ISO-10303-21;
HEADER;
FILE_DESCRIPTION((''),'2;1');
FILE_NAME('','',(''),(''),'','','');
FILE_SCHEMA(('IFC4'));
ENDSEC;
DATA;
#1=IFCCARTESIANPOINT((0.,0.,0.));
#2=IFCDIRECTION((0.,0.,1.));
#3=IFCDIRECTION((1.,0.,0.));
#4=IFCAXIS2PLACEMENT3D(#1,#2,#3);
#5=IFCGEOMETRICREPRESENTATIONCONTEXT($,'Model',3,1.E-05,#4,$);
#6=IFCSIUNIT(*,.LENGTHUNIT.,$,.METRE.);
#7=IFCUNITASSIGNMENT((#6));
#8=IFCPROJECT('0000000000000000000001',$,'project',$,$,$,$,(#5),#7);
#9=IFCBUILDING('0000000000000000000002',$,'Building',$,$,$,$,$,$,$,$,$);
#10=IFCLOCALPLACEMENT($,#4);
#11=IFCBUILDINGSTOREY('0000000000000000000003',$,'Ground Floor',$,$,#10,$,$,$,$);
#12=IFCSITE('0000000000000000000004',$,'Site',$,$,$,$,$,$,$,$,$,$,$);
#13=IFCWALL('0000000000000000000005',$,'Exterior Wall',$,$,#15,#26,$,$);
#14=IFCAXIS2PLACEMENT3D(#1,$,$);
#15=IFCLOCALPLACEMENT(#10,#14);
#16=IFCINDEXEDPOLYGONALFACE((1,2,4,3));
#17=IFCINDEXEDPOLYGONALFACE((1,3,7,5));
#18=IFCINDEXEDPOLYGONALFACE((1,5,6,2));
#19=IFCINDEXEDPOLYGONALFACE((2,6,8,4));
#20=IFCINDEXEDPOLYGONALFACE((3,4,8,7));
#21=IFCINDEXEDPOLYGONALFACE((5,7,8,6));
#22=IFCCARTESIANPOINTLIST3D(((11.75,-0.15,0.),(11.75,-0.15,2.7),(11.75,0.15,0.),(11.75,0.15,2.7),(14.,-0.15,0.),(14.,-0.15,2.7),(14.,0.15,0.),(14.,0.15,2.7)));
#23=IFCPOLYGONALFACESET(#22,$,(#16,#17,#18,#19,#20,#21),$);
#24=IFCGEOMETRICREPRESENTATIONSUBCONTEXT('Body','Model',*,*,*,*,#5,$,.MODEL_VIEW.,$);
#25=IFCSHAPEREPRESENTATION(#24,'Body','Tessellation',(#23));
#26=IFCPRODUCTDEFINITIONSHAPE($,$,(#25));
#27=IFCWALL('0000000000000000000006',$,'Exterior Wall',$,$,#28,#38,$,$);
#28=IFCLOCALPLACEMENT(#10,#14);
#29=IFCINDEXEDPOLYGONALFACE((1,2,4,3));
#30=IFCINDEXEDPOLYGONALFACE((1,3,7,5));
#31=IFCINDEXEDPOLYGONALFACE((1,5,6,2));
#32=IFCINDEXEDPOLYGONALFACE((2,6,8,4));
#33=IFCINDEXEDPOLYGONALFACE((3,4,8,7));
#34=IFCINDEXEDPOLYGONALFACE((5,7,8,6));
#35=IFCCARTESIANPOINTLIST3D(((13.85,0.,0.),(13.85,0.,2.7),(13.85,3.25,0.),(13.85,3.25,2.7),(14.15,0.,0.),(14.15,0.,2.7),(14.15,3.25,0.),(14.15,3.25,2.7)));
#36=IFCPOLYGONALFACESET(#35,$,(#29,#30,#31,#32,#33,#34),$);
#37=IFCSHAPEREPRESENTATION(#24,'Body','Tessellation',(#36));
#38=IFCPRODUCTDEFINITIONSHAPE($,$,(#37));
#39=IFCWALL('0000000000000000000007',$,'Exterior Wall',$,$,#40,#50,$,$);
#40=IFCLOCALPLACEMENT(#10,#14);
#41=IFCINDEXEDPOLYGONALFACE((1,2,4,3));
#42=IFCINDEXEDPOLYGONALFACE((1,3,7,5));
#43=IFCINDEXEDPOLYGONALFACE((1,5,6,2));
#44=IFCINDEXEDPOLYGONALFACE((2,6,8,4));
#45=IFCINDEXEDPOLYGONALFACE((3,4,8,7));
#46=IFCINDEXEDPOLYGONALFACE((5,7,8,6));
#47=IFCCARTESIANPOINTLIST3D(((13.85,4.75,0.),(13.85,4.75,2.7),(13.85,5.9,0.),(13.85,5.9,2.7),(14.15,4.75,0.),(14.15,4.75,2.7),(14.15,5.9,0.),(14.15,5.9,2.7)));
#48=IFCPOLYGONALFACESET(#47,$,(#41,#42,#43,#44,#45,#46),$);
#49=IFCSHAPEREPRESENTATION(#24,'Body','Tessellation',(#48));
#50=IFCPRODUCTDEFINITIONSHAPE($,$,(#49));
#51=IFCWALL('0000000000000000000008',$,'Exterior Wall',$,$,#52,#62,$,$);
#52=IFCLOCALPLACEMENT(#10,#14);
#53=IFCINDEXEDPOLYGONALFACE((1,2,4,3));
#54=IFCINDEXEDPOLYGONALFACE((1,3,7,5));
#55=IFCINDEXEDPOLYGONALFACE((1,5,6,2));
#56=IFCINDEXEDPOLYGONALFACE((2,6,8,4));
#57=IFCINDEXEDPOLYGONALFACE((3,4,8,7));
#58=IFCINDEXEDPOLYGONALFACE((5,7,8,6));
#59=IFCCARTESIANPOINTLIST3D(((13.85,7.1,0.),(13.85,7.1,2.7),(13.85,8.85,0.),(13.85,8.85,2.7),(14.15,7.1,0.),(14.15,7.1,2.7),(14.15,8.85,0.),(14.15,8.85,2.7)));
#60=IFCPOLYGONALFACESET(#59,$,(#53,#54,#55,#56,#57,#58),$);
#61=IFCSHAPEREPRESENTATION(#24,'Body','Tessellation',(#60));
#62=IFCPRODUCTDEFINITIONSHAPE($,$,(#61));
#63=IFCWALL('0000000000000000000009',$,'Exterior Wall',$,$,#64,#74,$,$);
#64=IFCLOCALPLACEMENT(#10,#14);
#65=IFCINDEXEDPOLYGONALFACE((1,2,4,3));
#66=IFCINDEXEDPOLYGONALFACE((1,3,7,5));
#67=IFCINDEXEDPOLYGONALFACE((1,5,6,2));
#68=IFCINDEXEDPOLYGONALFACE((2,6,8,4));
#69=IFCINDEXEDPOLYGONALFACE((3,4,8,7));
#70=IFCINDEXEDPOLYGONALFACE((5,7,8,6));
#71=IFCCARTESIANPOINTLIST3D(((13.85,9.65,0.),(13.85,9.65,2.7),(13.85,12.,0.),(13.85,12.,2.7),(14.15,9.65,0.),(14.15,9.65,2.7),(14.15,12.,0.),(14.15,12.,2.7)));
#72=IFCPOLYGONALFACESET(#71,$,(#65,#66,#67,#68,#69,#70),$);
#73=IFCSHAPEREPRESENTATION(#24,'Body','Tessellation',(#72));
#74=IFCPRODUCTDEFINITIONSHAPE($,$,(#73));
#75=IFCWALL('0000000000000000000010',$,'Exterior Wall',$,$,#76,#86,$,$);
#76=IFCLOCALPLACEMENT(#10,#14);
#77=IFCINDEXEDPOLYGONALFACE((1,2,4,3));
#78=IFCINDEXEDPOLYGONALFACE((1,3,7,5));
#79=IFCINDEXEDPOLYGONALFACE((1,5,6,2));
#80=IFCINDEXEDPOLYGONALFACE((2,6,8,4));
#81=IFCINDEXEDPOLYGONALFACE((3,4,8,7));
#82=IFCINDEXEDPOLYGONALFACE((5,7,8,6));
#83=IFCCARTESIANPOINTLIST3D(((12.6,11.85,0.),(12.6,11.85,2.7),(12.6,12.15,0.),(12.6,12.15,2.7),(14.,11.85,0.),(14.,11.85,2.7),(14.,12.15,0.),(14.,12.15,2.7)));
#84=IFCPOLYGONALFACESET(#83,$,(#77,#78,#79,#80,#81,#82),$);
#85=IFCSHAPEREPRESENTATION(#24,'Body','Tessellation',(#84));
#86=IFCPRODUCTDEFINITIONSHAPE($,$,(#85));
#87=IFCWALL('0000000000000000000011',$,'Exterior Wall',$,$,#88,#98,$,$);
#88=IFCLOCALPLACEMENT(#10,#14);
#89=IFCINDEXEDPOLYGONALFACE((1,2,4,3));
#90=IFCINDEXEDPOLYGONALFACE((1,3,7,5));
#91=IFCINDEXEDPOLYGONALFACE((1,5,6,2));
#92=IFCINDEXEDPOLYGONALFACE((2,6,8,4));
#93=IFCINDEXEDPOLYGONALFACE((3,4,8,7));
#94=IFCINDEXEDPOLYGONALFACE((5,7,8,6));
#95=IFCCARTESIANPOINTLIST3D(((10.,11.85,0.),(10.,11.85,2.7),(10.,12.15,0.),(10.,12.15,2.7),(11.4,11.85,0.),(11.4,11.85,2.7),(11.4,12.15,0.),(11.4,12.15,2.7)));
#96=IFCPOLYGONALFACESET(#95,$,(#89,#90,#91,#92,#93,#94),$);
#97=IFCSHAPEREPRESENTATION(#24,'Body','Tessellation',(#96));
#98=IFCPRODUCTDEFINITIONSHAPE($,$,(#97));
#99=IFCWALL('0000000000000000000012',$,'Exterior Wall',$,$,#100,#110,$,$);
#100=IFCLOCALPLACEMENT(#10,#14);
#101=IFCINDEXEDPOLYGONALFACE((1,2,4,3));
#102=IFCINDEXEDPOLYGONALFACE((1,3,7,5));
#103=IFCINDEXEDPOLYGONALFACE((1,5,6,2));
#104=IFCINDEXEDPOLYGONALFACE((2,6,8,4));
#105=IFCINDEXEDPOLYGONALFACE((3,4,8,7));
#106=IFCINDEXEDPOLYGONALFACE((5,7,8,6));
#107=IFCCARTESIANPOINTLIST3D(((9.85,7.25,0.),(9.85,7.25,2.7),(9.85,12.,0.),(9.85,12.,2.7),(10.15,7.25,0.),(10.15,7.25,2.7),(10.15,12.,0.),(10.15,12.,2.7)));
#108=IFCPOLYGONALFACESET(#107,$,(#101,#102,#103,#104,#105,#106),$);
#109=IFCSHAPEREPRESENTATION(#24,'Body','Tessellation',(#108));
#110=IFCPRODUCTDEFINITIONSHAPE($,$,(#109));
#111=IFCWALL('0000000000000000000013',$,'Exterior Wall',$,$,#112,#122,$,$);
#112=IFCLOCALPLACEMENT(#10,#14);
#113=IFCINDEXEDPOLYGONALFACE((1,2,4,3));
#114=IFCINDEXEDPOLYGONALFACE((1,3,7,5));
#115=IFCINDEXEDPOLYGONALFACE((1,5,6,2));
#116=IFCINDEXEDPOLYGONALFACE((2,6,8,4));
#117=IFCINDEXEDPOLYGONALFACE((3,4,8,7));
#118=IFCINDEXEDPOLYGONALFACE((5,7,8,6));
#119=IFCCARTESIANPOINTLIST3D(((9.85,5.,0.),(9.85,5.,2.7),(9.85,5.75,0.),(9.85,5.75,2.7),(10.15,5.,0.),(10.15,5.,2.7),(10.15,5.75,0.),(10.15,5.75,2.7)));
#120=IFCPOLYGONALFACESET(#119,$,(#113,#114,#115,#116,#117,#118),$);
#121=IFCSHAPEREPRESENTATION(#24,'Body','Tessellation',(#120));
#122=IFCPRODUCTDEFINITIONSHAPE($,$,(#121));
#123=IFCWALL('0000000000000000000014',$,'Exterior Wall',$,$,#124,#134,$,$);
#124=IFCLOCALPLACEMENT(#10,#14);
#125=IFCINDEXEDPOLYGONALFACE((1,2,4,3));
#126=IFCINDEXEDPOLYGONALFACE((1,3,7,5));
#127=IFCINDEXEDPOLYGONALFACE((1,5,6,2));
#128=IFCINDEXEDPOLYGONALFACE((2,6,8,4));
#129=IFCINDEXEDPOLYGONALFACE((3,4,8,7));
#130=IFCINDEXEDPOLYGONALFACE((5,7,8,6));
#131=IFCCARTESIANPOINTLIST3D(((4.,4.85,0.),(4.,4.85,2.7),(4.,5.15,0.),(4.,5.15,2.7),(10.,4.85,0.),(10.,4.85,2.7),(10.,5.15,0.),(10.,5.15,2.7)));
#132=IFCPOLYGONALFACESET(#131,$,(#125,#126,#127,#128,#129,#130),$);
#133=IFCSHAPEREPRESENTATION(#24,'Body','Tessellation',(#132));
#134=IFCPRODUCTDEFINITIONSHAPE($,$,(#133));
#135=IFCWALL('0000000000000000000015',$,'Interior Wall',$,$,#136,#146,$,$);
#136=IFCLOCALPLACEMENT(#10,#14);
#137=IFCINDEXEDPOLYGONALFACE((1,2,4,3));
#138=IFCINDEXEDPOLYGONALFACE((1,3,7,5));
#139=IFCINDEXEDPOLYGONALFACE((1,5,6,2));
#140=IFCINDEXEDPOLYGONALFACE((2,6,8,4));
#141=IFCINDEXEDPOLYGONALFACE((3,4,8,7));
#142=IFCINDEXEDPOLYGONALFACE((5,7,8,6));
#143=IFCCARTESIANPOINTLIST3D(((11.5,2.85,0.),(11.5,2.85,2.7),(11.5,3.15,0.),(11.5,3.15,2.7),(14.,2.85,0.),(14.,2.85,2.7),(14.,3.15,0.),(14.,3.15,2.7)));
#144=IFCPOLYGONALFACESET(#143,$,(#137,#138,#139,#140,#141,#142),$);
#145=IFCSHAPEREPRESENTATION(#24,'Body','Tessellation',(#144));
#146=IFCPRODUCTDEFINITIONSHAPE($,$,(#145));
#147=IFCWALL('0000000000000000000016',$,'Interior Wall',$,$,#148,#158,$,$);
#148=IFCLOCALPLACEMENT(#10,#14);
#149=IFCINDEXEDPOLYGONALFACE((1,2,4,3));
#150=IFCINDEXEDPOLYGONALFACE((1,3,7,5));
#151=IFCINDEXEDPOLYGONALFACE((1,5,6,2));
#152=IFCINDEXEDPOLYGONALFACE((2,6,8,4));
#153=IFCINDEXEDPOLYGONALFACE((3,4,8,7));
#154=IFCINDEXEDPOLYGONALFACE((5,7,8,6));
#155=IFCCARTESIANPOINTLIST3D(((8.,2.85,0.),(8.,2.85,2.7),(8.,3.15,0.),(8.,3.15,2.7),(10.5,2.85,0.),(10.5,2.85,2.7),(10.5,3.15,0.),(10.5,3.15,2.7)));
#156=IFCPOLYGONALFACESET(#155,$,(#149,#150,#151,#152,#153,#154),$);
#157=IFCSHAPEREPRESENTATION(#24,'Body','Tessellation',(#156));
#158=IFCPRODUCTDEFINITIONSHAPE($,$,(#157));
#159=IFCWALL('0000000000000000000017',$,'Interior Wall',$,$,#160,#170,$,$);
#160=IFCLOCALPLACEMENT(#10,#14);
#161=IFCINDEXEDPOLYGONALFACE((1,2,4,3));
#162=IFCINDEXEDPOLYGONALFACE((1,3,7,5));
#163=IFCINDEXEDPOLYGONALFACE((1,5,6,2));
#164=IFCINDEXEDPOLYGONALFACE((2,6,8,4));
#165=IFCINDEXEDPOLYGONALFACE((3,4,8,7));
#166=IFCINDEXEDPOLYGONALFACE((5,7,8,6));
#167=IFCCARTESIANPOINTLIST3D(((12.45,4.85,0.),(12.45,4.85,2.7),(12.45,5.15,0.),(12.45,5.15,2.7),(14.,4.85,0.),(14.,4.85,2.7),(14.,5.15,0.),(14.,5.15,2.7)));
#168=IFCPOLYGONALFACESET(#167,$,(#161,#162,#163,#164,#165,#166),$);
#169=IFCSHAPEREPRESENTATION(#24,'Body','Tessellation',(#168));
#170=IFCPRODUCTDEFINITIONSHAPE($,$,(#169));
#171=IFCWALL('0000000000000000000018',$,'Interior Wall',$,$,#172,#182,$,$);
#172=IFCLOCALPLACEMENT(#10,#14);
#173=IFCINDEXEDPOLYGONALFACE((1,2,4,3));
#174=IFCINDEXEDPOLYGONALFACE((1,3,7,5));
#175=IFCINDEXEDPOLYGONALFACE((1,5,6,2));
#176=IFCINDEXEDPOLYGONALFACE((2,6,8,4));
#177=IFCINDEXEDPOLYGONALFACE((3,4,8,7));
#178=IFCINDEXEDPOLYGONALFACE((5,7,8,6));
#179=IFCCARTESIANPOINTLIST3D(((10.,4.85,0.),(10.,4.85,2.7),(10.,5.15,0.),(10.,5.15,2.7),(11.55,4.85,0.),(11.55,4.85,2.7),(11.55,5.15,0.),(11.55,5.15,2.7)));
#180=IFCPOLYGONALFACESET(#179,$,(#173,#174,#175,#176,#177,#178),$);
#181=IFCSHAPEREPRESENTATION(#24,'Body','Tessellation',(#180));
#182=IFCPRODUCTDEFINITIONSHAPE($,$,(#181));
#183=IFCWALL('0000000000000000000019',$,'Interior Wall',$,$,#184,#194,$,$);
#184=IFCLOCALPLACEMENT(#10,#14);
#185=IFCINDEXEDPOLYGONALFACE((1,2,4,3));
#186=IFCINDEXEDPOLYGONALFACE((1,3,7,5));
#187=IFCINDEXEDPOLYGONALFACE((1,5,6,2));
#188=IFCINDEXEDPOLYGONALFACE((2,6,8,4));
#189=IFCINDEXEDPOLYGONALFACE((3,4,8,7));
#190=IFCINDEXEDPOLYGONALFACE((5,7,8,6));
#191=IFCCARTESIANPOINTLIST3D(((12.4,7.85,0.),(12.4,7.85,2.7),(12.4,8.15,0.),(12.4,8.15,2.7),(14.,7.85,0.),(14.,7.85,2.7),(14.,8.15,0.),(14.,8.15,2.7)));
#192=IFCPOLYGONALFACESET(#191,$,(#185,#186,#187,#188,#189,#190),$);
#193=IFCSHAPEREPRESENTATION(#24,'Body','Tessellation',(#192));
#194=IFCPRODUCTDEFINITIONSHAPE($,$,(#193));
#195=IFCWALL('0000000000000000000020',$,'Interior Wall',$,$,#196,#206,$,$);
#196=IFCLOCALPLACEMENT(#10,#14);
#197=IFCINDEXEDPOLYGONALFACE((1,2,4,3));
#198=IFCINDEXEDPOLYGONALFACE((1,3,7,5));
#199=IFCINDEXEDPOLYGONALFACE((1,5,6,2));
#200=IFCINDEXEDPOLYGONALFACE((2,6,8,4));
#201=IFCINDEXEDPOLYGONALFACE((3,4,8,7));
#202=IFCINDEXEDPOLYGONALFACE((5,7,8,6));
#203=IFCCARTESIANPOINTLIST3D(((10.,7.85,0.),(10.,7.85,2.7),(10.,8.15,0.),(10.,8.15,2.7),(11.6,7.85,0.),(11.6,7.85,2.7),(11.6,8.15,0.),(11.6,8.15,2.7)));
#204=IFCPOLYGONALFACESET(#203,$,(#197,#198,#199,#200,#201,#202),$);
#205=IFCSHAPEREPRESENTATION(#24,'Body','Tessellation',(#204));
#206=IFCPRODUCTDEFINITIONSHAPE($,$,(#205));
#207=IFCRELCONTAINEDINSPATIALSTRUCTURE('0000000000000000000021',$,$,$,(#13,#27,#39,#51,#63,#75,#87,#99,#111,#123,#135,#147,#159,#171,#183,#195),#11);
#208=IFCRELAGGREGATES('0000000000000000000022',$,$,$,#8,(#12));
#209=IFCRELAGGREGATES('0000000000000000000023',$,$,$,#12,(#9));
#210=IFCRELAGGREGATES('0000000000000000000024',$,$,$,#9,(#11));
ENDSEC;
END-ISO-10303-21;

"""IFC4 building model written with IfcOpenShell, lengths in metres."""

from ifc_helpers import new_model, si_unit, frame, origin_with_axes, place, context, subcontext, project, spatial, indexed_curve, outline, extrude, element, save


model = new_model("IFC4")

# Units and contexts
model_context = context("Model", 3, precision=1e-05, world=origin_with_axes())
body_context = subcontext(model_context, "Body", "Model", "MODEL_VIEW")
ifc_project = project(units=[si_unit("LENGTHUNIT", "METRE")], contexts=[model_context])

# Site, building, storey
site = spatial("IfcSite", under=ifc_project, Name="Site")
building = spatial("IfcBuilding", under=site, Name="Building")
storey_placement = place(None, origin_with_axes())
storey = spatial("IfcBuildingStorey", under=building, at=storey_placement, Name="Ground Floor")

# Walls
wall_1_placement = place(storey_placement, frame((11.75, 0.0, 0.0), z_axis=(0.0, 0.0, 1.0), x_axis=(1.0, 0.0, 0.0)))
element("IfcWall", 1, at=wall_1_placement, inside=storey, Name="Exterior Wall", context=body_context, shape_type="SweptSolid", body=[
    extrude(outline(indexed_curve([(0.0, 0.0), (0.0, 0.3), (2.25, 0.3), (2.25, 0.0), (0.0, 0.0)], self_intersect=False)), frame((0.0, -0.15, 0.0), z_axis=(0.0, 0.0, 1.0), x_axis=(1.0, 0.0, 0.0)), (0.0, 0.0, 1.0), 2.7),
])
wall_2_placement = place(storey_placement, frame((14.0, 0.0, 0.0), z_axis=(0.0, 0.0, 1.0), x_axis=(0.0, 1.0, 0.0)))
element("IfcWall", 2, at=wall_2_placement, inside=storey, Name="Exterior Wall", context=body_context, shape_type="SweptSolid", body=[
    extrude(outline(indexed_curve([(0.0, 0.0), (0.0, 0.3), (3.25, 0.3), (3.25, 0.0), (0.0, 0.0)], self_intersect=False)), frame((0.0, -0.15, 0.0), z_axis=(0.0, 0.0, 1.0), x_axis=(1.0, 0.0, 0.0)), (0.0, 0.0, 1.0), 2.7),
])
wall_3_placement = place(storey_placement, frame((14.0, 4.75, 0.0), z_axis=(0.0, 0.0, 1.0), x_axis=(0.0, 1.0, 0.0)))
element("IfcWall", 3, at=wall_3_placement, inside=storey, Name="Exterior Wall", context=body_context, shape_type="SweptSolid", body=[
    extrude(outline(indexed_curve([(0.0, 0.0), (0.0, 0.3), (1.15, 0.3), (1.15, 0.0), (0.0, 0.0)], self_intersect=False)), frame((0.0, -0.15, 0.0), z_axis=(0.0, 0.0, 1.0), x_axis=(1.0, 0.0, 0.0)), (0.0, 0.0, 1.0), 2.7),
])
wall_4_placement = place(storey_placement, frame((14.0, 7.1, 0.0), z_axis=(0.0, 0.0, 1.0), x_axis=(0.0, 1.0, 0.0)))
element("IfcWall", 4, at=wall_4_placement, inside=storey, Name="Exterior Wall", context=body_context, shape_type="SweptSolid", body=[
    extrude(outline(indexed_curve([(0.0, 0.0), (0.0, 0.3), (1.75, 0.3), (1.75, 0.0), (0.0, 0.0)], self_intersect=False)), frame((0.0, -0.15, 0.0), z_axis=(0.0, 0.0, 1.0), x_axis=(1.0, 0.0, 0.0)), (0.0, 0.0, 1.0), 2.7),
])
wall_5_placement = place(storey_placement, frame((14.0, 9.65, 0.0), z_axis=(0.0, 0.0, 1.0), x_axis=(0.0, 1.0, 0.0)))
element("IfcWall", 5, at=wall_5_placement, inside=storey, Name="Exterior Wall", context=body_context, shape_type="SweptSolid", body=[
    extrude(outline(indexed_curve([(0.0, 0.0), (0.0, 0.3), (2.35, 0.3), (2.35, 0.0), (0.0, 0.0)], self_intersect=False)), frame((0.0, -0.15, 0.0), z_axis=(0.0, 0.0, 1.0), x_axis=(1.0, 0.0, 0.0)), (0.0, 0.0, 1.0), 2.7),
])
for number, where, z_axis, x_axis, name in (
    (6, (14.0, 12.0, 0.0), (0.0, 0.0, 1.0), (-1.0, 0.0, 0.0), "Exterior Wall"),
    (7, (11.4, 12.0, 0.0), (0.0, 0.0, 1.0), (-1.0, 0.0, 0.0), "Exterior Wall"),
):
    element("IfcWall", number, at=place(storey_placement, frame(where, z_axis=z_axis, x_axis=x_axis)), inside=storey, Name=name, context=body_context, shape_type="SweptSolid", body=[
        extrude(outline(indexed_curve([(0.0, 0.0), (0.0, 0.3), (1.4, 0.3), (1.4, 0.0), (0.0, 0.0)], self_intersect=False)), frame((0.0, -0.15, 0.0), z_axis=(0.0, 0.0, 1.0), x_axis=(1.0, 0.0, 0.0)), (0.0, 0.0, 1.0), 2.7),
    ])
wall_6_placement = place(storey_placement, frame((10.0, 12.0, 0.0), z_axis=(0.0, 0.0, 1.0), x_axis=(0.0, -1.0, 0.0)))
element("IfcWall", 8, at=wall_6_placement, inside=storey, Name="Exterior Wall", context=body_context, shape_type="SweptSolid", body=[
    extrude(outline(indexed_curve([(0.0, 0.0), (0.0, 0.3), (4.75, 0.3), (4.75, 0.0), (0.0, 0.0)], self_intersect=False)), frame((0.0, -0.15, 0.0), z_axis=(0.0, 0.0, 1.0), x_axis=(1.0, 0.0, 0.0)), (0.0, 0.0, 1.0), 2.7),
])
wall_7_placement = place(storey_placement, frame((10.0, 5.75, 0.0), z_axis=(0.0, 0.0, 1.0), x_axis=(0.0, -1.0, 0.0)))
element("IfcWall", 9, at=wall_7_placement, inside=storey, Name="Exterior Wall", context=body_context, shape_type="SweptSolid", body=[
    extrude(outline(indexed_curve([(0.0, 0.0), (0.0, 0.3), (0.75, 0.3), (0.75, 0.0), (0.0, 0.0)], self_intersect=False)), frame((0.0, -0.15, 0.0), z_axis=(0.0, 0.0, 1.0), x_axis=(1.0, 0.0, 0.0)), (0.0, 0.0, 1.0), 2.7),
])
wall_8_placement = place(storey_placement, frame((10.0, 5.0, 0.0), z_axis=(0.0, 0.0, 1.0), x_axis=(-1.0, 0.0, 0.0)))
element("IfcWall", 10, at=wall_8_placement, inside=storey, Name="Exterior Wall", context=body_context, shape_type="SweptSolid", body=[
    extrude(outline(indexed_curve([(0.0, 0.0), (0.0, 0.3), (6.0, 0.3), (6.0, 0.0), (0.0, 0.0)], self_intersect=False)), frame((0.0, -0.15, 0.0), z_axis=(0.0, 0.0, 1.0), x_axis=(1.0, 0.0, 0.0)), (0.0, 0.0, 1.0), 2.7),
])
for number, where, z_axis, x_axis, name in (
    (11, (14.0, 3.0, 0.0), (0.0, 0.0, 1.0), (-1.0, 0.0, 0.0), "Interior Wall"),
    (12, (10.5, 3.0, 0.0), (0.0, 0.0, 1.0), (-1.0, 0.0, 0.0), "Interior Wall"),
):
    element("IfcWall", number, at=place(storey_placement, frame(where, z_axis=z_axis, x_axis=x_axis)), inside=storey, Name=name, context=body_context, shape_type="SweptSolid", body=[
        extrude(outline(indexed_curve([(0.0, 0.0), (0.0, 0.3), (2.5, 0.3), (2.5, 0.0), (0.0, 0.0)], self_intersect=False)), frame((0.0, -0.15, 0.0), z_axis=(0.0, 0.0, 1.0), x_axis=(1.0, 0.0, 0.0)), (0.0, 0.0, 1.0), 2.7),
    ])
for number, where, z_axis, x_axis, name in (
    (13, (14.0, 5.0, 0.0), (0.0, 0.0, 1.0), (-1.0, 0.0, 0.0), "Interior Wall"),
    (14, (11.55, 5.0, 0.0), (0.0, 0.0, 1.0), (-1.0, 0.0, 0.0), "Interior Wall"),
):
    element("IfcWall", number, at=place(storey_placement, frame(where, z_axis=z_axis, x_axis=x_axis)), inside=storey, Name=name, context=body_context, shape_type="SweptSolid", body=[
        extrude(outline(indexed_curve([(0.0, 0.0), (0.0, 0.3), (1.55, 0.3), (1.55, 0.0), (0.0, 0.0)], self_intersect=False)), frame((0.0, -0.15, 0.0), z_axis=(0.0, 0.0, 1.0), x_axis=(1.0, 0.0, 0.0)), (0.0, 0.0, 1.0), 2.7),
    ])
for number, where, z_axis, x_axis, name in (
    (15, (14.0, 8.0, 0.0), (0.0, 0.0, 1.0), (-1.0, 0.0, 0.0), "Interior Wall"),
    (16, (11.6, 8.0, 0.0), (0.0, 0.0, 1.0), (-1.0, 0.0, 0.0), "Interior Wall"),
):
    element("IfcWall", number, at=place(storey_placement, frame(where, z_axis=z_axis, x_axis=x_axis)), inside=storey, Name=name, context=body_context, shape_type="SweptSolid", body=[
        extrude(outline(indexed_curve([(0.0, 0.0), (0.0, 0.3), (1.6, 0.3), (1.6, 0.0), (0.0, 0.0)], self_intersect=False)), frame((0.0, -0.15, 0.0), z_axis=(0.0, 0.0, 1.0), x_axis=(1.0, 0.0, 0.0)), (0.0, 0.0, 1.0), 2.7),
    ])

save(model, "model.ifc")
